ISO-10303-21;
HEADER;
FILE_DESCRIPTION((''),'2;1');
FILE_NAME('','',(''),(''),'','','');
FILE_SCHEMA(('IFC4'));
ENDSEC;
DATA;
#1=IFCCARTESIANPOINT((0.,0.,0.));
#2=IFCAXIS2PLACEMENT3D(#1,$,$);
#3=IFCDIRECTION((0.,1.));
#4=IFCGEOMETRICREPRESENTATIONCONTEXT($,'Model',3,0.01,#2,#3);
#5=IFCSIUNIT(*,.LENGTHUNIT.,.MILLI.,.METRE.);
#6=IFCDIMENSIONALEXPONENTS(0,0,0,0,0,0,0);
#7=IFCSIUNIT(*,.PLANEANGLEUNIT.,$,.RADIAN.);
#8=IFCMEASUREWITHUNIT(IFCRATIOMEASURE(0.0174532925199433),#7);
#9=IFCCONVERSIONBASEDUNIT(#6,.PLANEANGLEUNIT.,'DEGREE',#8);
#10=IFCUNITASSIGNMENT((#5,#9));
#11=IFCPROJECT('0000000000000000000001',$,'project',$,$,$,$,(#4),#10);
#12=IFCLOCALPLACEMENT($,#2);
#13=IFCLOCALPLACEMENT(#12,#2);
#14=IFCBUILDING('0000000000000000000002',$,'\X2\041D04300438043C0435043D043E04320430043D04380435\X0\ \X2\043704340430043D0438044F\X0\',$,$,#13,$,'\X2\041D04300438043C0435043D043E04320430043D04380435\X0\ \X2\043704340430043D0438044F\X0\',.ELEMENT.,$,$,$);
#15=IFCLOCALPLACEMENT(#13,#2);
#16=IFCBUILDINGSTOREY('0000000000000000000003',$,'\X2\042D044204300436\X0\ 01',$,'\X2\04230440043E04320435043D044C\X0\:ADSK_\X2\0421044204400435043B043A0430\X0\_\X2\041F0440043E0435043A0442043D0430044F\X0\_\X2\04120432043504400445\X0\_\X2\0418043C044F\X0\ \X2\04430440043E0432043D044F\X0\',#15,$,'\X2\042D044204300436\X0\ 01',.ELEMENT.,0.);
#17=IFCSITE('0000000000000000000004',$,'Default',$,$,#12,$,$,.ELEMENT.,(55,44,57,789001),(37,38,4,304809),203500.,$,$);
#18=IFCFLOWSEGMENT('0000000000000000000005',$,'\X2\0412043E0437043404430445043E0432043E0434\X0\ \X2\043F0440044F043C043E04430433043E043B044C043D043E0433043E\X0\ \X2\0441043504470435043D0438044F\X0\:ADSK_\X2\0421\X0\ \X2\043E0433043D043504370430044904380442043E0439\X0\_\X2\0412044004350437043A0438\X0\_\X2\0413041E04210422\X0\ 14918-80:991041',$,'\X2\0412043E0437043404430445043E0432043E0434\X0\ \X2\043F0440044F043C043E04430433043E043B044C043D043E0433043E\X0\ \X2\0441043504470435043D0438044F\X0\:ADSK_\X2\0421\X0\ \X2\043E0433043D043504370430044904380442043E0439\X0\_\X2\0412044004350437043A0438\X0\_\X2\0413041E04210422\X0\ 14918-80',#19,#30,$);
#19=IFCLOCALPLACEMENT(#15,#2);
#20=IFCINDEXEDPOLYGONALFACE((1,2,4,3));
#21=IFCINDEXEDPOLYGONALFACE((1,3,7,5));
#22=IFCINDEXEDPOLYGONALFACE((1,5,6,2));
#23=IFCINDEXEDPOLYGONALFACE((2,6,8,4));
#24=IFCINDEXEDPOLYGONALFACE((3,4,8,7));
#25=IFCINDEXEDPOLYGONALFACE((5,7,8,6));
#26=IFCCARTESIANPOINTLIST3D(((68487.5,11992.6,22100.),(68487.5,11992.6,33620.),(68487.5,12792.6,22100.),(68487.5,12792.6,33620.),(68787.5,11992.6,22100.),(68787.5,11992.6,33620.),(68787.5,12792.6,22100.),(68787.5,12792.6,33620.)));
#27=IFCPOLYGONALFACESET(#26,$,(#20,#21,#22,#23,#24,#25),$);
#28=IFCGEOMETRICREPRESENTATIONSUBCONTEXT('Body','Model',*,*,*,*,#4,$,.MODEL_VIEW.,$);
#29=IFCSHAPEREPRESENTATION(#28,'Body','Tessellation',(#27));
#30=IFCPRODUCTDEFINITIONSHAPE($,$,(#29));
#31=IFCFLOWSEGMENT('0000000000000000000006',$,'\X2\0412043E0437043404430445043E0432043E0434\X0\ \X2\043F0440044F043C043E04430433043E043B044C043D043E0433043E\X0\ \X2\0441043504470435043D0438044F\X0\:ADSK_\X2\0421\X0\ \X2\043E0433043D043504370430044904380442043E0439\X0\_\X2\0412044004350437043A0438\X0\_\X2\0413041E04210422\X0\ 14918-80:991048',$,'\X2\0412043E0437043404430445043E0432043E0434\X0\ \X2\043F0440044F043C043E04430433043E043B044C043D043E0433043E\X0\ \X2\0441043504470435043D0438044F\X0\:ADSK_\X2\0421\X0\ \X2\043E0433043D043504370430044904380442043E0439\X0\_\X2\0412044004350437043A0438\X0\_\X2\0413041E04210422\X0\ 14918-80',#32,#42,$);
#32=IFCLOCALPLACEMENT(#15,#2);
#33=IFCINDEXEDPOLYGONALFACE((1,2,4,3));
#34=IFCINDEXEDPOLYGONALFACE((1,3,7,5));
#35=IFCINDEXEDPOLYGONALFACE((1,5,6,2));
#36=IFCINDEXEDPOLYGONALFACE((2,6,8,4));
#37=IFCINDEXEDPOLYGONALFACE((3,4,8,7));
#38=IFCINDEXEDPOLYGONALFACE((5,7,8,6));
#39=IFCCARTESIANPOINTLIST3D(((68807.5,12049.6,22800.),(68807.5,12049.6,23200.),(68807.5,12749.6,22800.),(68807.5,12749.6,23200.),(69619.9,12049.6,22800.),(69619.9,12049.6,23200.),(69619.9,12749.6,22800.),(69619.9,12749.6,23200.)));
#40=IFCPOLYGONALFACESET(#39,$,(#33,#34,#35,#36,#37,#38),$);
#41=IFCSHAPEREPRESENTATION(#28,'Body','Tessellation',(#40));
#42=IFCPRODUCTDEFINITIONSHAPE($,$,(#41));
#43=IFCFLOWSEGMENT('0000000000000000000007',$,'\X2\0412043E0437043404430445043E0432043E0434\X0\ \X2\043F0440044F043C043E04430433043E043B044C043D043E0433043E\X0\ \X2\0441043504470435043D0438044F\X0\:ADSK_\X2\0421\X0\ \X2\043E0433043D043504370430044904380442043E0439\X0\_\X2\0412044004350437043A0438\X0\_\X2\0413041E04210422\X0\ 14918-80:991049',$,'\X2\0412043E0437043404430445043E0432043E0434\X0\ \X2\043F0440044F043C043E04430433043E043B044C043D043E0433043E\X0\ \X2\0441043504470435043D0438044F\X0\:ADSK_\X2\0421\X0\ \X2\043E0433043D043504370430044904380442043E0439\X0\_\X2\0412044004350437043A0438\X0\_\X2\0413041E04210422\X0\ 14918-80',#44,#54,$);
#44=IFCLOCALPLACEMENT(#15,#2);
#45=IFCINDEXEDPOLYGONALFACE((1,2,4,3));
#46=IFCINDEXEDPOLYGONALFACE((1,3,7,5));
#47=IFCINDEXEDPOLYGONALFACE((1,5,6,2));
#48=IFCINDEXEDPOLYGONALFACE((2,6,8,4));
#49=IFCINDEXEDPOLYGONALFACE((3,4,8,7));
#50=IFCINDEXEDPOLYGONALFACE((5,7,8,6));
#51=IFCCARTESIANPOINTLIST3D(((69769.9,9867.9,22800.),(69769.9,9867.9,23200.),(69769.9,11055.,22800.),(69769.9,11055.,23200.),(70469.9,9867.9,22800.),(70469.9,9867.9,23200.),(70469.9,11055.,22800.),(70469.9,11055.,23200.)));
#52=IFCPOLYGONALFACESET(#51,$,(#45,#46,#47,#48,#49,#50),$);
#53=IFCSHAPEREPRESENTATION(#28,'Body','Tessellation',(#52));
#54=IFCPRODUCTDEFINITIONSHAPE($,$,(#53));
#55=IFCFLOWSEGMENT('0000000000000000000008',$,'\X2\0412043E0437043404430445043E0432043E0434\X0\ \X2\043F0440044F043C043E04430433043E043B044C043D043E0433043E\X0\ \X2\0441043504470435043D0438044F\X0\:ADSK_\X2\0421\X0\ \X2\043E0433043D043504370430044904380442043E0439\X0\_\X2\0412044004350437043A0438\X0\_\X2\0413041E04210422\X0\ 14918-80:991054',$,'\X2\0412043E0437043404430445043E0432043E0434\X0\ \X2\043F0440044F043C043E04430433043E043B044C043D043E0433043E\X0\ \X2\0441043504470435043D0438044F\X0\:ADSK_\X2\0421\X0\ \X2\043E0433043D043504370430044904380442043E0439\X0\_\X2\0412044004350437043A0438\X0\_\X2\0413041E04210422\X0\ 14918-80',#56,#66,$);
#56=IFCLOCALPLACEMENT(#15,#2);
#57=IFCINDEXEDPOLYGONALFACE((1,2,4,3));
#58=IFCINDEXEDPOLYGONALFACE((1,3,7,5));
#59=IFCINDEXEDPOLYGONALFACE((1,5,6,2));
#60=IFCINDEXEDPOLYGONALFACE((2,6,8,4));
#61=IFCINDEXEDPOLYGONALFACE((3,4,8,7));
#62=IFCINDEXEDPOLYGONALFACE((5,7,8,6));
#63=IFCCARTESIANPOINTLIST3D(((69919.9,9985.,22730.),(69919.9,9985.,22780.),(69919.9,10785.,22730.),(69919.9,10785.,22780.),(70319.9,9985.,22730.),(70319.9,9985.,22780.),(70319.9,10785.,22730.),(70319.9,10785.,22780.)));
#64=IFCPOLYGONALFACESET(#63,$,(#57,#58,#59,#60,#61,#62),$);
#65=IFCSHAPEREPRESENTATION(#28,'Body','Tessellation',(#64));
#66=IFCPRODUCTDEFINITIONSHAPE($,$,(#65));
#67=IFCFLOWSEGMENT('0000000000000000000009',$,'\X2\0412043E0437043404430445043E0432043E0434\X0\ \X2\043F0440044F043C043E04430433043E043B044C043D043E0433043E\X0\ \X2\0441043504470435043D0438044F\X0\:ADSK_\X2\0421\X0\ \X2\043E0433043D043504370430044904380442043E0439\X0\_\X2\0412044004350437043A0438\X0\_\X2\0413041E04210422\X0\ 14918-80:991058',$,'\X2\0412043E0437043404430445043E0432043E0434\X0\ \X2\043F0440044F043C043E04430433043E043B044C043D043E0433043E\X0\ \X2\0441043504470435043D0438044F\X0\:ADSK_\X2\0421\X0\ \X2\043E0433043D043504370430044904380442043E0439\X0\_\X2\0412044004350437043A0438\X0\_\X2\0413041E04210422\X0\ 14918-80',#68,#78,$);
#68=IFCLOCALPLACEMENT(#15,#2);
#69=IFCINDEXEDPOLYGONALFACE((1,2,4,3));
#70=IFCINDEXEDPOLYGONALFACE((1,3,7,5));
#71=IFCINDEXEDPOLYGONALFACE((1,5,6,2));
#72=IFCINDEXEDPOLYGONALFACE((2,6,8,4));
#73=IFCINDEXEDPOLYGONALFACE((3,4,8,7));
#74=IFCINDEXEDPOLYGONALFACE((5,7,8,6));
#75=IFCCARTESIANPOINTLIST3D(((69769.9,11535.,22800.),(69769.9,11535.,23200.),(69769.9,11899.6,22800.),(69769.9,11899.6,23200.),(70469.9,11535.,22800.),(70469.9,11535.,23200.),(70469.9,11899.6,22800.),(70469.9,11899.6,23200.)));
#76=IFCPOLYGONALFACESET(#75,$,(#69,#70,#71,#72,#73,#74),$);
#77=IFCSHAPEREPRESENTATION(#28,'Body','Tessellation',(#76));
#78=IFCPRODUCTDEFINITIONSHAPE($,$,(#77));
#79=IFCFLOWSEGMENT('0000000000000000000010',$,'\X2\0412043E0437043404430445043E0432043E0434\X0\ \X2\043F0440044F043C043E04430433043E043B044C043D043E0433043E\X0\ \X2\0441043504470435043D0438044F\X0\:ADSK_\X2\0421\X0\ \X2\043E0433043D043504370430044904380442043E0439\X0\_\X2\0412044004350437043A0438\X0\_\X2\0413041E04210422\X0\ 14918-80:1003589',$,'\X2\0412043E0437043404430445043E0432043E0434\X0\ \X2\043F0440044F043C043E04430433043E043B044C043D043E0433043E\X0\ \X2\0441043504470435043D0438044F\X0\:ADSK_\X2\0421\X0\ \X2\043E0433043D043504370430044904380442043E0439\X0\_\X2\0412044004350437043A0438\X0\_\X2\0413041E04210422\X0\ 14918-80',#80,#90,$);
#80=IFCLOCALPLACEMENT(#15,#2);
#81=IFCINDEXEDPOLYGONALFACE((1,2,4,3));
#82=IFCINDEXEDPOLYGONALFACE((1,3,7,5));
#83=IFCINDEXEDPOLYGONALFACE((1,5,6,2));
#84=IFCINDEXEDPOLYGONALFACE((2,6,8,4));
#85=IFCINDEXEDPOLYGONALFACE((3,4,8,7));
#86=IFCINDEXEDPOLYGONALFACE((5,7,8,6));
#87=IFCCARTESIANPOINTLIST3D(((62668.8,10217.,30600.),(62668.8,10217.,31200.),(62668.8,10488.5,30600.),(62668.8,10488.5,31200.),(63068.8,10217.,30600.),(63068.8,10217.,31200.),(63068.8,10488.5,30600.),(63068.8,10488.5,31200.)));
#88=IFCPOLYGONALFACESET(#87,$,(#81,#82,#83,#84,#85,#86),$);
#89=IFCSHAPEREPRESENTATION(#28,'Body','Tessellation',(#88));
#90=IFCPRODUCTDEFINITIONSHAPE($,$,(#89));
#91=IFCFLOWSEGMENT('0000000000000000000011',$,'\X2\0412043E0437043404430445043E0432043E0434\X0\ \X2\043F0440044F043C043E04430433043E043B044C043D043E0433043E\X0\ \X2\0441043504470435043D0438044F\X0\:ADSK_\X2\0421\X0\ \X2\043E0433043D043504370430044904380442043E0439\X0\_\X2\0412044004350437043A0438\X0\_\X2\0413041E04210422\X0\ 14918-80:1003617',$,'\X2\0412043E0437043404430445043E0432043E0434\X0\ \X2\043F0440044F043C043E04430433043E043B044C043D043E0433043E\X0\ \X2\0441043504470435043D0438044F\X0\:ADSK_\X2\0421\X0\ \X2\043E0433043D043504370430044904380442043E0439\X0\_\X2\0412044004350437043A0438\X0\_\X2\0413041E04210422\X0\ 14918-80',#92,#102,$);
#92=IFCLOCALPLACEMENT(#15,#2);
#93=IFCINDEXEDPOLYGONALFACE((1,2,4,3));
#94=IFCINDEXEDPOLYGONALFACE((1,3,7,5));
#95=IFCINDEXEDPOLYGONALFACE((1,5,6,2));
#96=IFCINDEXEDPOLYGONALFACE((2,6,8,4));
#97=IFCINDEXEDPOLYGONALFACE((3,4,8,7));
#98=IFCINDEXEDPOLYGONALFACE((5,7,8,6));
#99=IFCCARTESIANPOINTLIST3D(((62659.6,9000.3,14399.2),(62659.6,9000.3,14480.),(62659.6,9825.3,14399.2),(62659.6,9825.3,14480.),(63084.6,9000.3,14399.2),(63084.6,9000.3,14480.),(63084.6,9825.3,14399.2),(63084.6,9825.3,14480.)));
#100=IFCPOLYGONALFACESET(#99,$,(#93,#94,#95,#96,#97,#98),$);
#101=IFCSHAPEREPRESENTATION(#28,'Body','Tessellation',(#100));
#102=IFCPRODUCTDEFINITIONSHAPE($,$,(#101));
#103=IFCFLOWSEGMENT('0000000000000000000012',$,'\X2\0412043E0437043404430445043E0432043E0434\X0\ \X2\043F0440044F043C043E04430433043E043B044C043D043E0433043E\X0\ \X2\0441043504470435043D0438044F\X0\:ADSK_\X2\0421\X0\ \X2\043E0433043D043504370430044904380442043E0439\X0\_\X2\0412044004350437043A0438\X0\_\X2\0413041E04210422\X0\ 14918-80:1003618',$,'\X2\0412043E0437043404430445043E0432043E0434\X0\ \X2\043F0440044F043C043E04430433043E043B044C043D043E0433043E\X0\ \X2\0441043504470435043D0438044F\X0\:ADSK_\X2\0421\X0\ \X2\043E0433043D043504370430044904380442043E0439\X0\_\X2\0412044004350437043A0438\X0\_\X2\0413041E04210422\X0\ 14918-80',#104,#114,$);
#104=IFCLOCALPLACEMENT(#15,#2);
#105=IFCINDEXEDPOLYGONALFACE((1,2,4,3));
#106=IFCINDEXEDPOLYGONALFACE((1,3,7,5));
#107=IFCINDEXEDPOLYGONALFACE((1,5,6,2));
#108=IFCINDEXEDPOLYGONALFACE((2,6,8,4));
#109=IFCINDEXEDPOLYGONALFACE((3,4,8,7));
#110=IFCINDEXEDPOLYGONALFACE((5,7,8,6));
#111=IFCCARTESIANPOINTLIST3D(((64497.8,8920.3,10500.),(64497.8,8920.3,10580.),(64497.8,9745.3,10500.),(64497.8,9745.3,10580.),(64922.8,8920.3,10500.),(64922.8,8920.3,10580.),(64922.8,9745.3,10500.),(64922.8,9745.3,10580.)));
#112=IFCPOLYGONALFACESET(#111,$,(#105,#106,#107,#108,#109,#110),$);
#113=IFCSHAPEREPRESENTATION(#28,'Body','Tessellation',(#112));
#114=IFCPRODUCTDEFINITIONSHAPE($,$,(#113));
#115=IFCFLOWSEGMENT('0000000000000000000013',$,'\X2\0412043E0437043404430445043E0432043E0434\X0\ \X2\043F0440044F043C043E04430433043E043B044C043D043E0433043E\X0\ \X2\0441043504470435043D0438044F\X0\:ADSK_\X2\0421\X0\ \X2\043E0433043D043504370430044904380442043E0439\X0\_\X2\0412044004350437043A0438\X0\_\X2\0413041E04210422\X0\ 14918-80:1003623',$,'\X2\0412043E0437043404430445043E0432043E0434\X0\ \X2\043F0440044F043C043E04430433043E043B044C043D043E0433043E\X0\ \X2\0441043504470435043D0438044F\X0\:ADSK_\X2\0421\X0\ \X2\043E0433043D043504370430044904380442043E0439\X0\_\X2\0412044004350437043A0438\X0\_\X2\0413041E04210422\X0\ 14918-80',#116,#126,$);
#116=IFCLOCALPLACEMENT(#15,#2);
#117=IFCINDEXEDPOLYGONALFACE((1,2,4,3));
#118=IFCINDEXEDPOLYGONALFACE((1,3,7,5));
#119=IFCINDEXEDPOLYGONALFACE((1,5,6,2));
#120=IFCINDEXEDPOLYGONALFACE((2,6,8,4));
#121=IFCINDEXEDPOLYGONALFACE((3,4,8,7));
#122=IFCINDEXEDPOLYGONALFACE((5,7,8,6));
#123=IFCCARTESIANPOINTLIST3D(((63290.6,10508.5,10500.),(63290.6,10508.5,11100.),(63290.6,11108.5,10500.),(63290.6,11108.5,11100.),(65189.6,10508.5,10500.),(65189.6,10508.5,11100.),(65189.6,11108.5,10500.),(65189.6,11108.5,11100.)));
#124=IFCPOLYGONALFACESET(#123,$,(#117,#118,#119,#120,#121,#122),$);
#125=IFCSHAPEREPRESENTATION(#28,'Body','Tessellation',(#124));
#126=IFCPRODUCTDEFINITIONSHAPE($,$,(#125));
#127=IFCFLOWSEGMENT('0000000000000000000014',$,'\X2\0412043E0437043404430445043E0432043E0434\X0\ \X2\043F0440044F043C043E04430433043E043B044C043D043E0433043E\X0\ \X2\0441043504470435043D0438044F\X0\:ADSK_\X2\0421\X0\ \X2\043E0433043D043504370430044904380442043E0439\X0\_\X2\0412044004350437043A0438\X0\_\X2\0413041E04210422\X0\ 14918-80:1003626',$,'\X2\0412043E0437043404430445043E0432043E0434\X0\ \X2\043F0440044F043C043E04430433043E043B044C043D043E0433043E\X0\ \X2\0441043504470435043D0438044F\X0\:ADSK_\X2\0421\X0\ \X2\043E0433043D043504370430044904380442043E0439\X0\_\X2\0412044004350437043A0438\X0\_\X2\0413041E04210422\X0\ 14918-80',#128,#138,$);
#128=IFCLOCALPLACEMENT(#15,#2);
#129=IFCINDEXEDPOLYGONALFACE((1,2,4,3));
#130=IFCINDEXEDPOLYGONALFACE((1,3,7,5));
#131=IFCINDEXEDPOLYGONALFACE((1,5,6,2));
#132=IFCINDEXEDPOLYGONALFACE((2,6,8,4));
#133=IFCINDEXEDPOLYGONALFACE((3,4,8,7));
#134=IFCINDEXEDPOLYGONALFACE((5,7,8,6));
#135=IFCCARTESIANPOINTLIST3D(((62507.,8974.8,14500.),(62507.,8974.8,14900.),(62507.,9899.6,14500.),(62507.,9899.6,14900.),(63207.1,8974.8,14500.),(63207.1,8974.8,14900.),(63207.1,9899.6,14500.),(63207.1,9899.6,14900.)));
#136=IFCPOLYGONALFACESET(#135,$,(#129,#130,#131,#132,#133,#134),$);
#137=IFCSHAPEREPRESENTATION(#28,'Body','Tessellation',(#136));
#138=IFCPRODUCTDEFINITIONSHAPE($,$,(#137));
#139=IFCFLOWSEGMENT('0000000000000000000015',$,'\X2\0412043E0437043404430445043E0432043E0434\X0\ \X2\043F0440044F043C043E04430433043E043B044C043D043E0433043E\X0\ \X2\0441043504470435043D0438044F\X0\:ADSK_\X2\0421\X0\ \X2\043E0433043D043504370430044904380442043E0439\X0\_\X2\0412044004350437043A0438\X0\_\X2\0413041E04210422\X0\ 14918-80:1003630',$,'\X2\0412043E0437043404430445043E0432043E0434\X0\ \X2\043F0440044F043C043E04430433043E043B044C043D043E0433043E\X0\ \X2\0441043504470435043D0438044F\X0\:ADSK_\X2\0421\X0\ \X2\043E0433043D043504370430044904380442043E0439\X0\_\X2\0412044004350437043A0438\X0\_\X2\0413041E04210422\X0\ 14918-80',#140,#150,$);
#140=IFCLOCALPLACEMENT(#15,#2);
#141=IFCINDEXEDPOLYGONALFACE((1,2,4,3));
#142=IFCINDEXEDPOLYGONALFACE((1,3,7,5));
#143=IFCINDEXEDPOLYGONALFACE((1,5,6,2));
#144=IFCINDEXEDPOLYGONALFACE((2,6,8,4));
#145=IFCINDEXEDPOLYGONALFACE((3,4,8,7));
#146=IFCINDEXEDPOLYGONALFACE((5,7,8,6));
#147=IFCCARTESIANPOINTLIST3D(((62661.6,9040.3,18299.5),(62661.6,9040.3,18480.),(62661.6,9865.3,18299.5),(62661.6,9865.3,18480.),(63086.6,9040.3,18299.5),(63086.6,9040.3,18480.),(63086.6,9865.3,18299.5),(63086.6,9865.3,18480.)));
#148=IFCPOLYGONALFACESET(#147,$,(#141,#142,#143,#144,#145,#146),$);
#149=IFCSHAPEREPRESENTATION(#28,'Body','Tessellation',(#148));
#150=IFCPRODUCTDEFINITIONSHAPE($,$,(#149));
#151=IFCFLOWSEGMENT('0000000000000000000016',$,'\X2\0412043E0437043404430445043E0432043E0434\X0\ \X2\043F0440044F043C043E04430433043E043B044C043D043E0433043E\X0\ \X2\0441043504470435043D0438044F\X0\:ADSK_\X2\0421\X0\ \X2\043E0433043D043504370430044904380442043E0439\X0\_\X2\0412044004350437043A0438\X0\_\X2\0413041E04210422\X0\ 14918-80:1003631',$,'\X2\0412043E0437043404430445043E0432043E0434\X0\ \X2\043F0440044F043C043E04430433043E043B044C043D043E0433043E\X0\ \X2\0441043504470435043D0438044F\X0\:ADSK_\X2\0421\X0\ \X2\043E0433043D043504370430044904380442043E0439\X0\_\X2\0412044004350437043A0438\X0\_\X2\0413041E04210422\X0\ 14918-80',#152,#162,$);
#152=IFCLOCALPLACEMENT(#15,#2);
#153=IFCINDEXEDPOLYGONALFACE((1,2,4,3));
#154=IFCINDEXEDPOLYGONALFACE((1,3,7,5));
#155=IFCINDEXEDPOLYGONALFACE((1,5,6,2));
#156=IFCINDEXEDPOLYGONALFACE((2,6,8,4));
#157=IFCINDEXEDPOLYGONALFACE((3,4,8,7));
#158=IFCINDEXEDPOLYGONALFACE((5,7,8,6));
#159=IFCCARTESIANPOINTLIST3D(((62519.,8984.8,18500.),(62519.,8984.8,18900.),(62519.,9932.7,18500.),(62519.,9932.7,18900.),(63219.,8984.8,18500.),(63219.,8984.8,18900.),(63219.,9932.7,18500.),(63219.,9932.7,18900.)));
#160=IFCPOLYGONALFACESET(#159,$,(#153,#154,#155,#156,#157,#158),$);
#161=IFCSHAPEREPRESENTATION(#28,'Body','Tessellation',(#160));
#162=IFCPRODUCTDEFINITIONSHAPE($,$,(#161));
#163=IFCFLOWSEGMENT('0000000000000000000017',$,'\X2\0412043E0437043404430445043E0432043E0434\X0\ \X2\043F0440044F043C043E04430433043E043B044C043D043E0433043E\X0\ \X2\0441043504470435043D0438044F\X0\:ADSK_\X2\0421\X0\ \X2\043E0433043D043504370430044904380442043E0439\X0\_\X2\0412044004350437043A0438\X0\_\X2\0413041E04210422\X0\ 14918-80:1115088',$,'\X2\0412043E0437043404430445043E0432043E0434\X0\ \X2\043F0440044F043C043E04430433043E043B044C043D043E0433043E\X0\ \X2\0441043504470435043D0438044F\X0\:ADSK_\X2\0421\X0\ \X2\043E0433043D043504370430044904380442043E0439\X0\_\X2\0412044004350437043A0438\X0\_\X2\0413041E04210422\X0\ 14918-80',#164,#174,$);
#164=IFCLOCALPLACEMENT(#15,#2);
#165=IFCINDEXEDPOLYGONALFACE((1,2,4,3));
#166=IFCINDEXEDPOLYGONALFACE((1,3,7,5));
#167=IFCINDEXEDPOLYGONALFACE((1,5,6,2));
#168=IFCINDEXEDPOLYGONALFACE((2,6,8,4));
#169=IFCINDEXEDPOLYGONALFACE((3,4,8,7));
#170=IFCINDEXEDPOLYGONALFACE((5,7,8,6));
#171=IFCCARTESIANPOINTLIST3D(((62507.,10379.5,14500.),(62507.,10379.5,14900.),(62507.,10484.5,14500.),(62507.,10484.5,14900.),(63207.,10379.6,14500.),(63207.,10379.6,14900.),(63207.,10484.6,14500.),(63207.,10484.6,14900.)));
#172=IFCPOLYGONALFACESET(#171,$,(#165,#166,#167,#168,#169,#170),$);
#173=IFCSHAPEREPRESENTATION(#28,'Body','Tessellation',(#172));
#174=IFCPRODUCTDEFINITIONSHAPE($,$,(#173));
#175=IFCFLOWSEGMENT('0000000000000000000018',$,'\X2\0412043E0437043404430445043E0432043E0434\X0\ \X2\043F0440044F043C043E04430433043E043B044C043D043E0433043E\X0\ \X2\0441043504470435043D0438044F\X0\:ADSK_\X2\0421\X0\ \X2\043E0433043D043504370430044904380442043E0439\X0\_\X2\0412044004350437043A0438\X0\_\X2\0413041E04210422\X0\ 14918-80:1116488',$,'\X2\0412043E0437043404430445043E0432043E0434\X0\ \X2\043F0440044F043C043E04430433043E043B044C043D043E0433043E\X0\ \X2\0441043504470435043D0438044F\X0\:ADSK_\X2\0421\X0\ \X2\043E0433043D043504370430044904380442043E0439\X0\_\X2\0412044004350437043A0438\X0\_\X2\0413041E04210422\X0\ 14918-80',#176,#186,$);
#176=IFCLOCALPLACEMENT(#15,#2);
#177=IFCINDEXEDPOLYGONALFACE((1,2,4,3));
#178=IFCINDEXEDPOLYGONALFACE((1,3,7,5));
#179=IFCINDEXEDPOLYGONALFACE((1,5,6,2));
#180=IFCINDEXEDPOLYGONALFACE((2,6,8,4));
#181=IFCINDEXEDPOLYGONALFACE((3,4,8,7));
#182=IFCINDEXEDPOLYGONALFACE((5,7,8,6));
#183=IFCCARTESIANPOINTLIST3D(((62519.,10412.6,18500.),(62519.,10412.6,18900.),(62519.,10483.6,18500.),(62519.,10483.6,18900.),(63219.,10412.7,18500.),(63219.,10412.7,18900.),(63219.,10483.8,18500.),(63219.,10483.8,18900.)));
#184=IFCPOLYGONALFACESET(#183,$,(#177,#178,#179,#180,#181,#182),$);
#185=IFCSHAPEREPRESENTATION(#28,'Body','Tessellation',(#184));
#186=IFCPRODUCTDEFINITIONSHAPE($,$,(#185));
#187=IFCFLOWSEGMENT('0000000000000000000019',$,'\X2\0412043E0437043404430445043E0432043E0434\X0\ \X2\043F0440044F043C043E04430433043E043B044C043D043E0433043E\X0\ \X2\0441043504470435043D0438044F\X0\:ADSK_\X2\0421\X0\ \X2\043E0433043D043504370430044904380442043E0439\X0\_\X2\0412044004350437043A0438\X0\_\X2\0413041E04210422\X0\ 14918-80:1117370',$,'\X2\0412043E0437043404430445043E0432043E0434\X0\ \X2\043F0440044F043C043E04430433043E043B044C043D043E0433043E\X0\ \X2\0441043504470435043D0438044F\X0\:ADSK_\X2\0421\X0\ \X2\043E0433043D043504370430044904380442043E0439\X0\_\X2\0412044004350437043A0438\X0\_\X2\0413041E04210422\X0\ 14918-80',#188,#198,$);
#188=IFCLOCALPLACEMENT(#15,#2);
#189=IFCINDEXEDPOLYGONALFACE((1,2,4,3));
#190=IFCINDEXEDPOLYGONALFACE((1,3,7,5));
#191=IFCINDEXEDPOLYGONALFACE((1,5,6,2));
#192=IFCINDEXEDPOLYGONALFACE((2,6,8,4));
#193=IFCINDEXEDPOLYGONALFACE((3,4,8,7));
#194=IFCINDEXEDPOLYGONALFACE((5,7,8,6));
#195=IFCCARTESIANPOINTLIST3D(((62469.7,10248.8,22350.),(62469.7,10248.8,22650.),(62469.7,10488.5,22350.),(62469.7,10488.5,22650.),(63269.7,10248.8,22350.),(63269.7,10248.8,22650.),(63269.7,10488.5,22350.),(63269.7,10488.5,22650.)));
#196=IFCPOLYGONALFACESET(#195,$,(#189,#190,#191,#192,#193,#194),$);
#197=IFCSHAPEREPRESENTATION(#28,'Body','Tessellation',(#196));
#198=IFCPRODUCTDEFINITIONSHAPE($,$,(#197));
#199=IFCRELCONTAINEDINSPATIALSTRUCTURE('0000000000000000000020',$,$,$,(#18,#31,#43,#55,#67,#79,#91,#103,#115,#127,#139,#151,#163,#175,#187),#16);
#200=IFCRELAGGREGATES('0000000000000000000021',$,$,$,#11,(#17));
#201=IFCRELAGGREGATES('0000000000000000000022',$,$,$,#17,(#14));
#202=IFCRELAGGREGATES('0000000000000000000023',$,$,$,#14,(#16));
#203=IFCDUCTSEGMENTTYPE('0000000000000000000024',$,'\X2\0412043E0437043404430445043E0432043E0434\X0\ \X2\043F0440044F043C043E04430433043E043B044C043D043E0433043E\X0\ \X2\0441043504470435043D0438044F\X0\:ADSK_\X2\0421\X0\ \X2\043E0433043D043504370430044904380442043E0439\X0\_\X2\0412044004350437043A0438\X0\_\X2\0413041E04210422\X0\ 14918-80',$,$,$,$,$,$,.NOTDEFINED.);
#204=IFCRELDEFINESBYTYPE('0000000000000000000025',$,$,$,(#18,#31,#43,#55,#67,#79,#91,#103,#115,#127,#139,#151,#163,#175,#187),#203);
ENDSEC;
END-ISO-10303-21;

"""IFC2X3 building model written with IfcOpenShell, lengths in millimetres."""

from ifc_helpers import new_model, entity, si_unit, converted_unit, direction, frame, origin, origin_2d_with_axis, place, context, subcontext, project, spatial, rectangle, extrude, type_object, element, save


model = new_model("IFC2X3")

# Units and contexts
model_context = context("Model", 3, precision=0.01, world=origin(), true_north=direction((0.0, 1.0)))
body_context = subcontext(model_context, "Body", "Model", "MODEL_VIEW")
ifc_project = project(units=[si_unit("LENGTHUNIT", "METRE", prefix="MILLI"), converted_unit("PLANEANGLEUNIT", "DEGREE", entity("IfcRatioMeasure", 0.0174532925199433), si_unit("PLANEANGLEUNIT", "RADIAN"), dimensions=[0, 0, 0, 0, 0, 0, 0])], contexts=[model_context])

# Site, building, storey
site_placement = place(None, origin())
site = spatial("IfcSite", under=ifc_project, at=site_placement, Name="Default", CompositionType="ELEMENT", RefLatitude=(55, 44, 57, 789001), RefLongitude=(37, 38, 4, 304809), RefElevation=203500.0)
building_placement = place(site_placement, origin())
building = spatial("IfcBuilding", under=site, at=building_placement, Name="Наименование здания", LongName="Наименование здания", CompositionType="ELEMENT")
storey_placement = place(building_placement, origin())
storey = spatial("IfcBuildingStorey", under=building, at=storey_placement, Name="Этаж 01", ObjectType="Уровень:ADSK_Стрелка_Проектная_Вверх_Имя уровня", LongName="Этаж 01", CompositionType="ELEMENT", Elevation=0.0)

# Flow segments
duct_segment_type = type_object("IfcDuctSegmentType", Name="Воздуховод прямоугольного сечения:ADSK_С огнезащитой_Врезки_ГОСТ 14918-80", PredefinedType="NOTDEFINED")
flow_segment_1_placement = place(storey_placement, frame((68487.5, 11992.6, 22100.0)))
element("IfcFlowSegment", 1, at=flow_segment_1_placement, inside=storey, type_object=duct_segment_type, Name="Воздуховод прямоугольного сечения:ADSK_С огнезащитой_Врезки_ГОСТ 14918-80:991041", ObjectType="Воздуховод прямоугольного сечения:ADSK_С огнезащитой_Врезки_ГОСТ 14918-80", context=body_context, shape_type="SweptSolid", body=[
    extrude(rectangle(XDim=300.0, YDim=800.0, at=origin_2d_with_axis()), frame((150.0, 400.0, 0.0), z_axis=(0.0, 0.0, 1.0), x_axis=(-1.0, 0.0, 0.0)), (0.0, 0.0, 1.0), 11520.0),
])
flow_segment_2_placement = place(storey_placement, frame((68807.5, 12049.6, 22800.0)))
element("IfcFlowSegment", 2, at=flow_segment_2_placement, inside=storey, type_object=duct_segment_type, Name="Воздуховод прямоугольного сечения:ADSK_С огнезащитой_Врезки_ГОСТ 14918-80:991048", ObjectType="Воздуховод прямоугольного сечения:ADSK_С огнезащитой_Врезки_ГОСТ 14918-80", context=body_context, shape_type="SweptSolid", body=[
    extrude(rectangle(XDim=812.4, YDim=700.0, at=origin_2d_with_axis()), frame((406.2, 350.0, 0.0), z_axis=(0.0, 0.0, 1.0), x_axis=(-1.0, 0.0, 0.0)), (0.0, 0.0, 1.0), 400.0),
])
flow_segment_3_placement = place(storey_placement, frame((69769.9, 9867.9, 22800.0)))
element("IfcFlowSegment", 3, at=flow_segment_3_placement, inside=storey, type_object=duct_segment_type, Name="Воздуховод прямоугольного сечения:ADSK_С огнезащитой_Врезки_ГОСТ 14918-80:991049", ObjectType="Воздуховод прямоугольного сечения:ADSK_С огнезащитой_Врезки_ГОСТ 14918-80", context=body_context, shape_type="SweptSolid", body=[
    extrude(rectangle(XDim=1187.1, YDim=700.0, at=origin_2d_with_axis()), frame((350.0, 593.5, 0.0), z_axis=(0.0, 0.0, 1.0), x_axis=(0.0, -1.0, 0.0)), (0.0, 0.0, 1.0), 400.0),
])
flow_segment_4_placement = place(storey_placement, frame((69919.9, 9985.0, 22730.0)))
element("IfcFlowSegment", 4, at=flow_segment_4_placement, inside=storey, type_object=duct_segment_type, Name="Воздуховод прямоугольного сечения:ADSK_С огнезащитой_Врезки_ГОСТ 14918-80:991054", ObjectType="Воздуховод прямоугольного сечения:ADSK_С огнезащитой_Врезки_ГОСТ 14918-80", context=body_context, shape_type="SweptSolid", body=[
    extrude(rectangle(XDim=800.0, YDim=400.0, at=origin_2d_with_axis()), frame((200.0, 400.0, 0.0), z_axis=(0.0, 0.0, 1.0), x_axis=(0.0, 1.0, 0.0)), (0.0, 0.0, 1.0), 50.0),
])
flow_segment_5_placement = place(storey_placement, frame((69769.9, 11535.0, 22800.0)))
element("IfcFlowSegment", 5, at=flow_segment_5_placement, inside=storey, type_object=duct_segment_type, Name="Воздуховод прямоугольного сечения:ADSK_С огнезащитой_Врезки_ГОСТ 14918-80:991058", ObjectType="Воздуховод прямоугольного сечения:ADSK_С огнезащитой_Врезки_ГОСТ 14918-80", context=body_context, shape_type="SweptSolid", body=[
    extrude(rectangle(XDim=364.6, YDim=700.0, at=origin_2d_with_axis()), frame((350.0, 182.3, 0.0), z_axis=(0.0, 0.0, 1.0), x_axis=(0.0, -1.0, 0.0)), (0.0, 0.0, 1.0), 400.0),
])
flow_segment_6_placement = place(storey_placement, frame((62668.8, 10217.0, 30600.0)))
element("IfcFlowSegment", 6, at=flow_segment_6_placement, inside=storey, type_object=duct_segment_type, Name="Воздуховод прямоугольного сечения:ADSK_С огнезащитой_Врезки_ГОСТ 14918-80:1003589", ObjectType="Воздуховод прямоугольного сечения:ADSK_С огнезащитой_Врезки_ГОСТ 14918-80", context=body_context, shape_type="SweptSolid", body=[
    extrude(rectangle(XDim=271.5, YDim=400.0, at=origin_2d_with_axis()), frame((200.0, 135.7, 0.0), z_axis=(0.0, 0.0, 1.0), x_axis=(0.0, 1.0, 0.0)), (0.0, 0.0, 1.0), 600.0),
])
flow_segment_7_placement = place(storey_placement, frame((62659.6, 9000.3, 14399.2)))
element("IfcFlowSegment", 7, at=flow_segment_7_placement, inside=storey, type_object=duct_segment_type, Name="Воздуховод прямоугольного сечения:ADSK_С огнезащитой_Врезки_ГОСТ 14918-80:1003617", ObjectType="Воздуховод прямоугольного сечения:ADSK_С огнезащитой_Врезки_ГОСТ 14918-80", context=body_context, shape_type="SweptSolid", body=[
    extrude(rectangle(XDim=425.0, YDim=825.0, at=origin_2d_with_axis()), frame((212.5, 412.5, 0.0)), (0.0, 0.0, 1.0), 80.7),
])
flow_segment_8_placement = place(storey_placement, frame((64497.8, 8920.3, 10500.0)))
element("IfcFlowSegment", 8, at=flow_segment_8_placement, inside=storey, type_object=duct_segment_type, Name="Воздуховод прямоугольного сечения:ADSK_С огнезащитой_Врезки_ГОСТ 14918-80:1003618", ObjectType="Воздуховод прямоугольного сечения:ADSK_С огнезащитой_Врезки_ГОСТ 14918-80", context=body_context, shape_type="SweptSolid", body=[
    extrude(rectangle(XDim=825.0, YDim=425.0, at=origin_2d_with_axis()), frame((212.5, 412.5, 0.0), z_axis=(0.0, 0.0, 1.0), x_axis=(0.0, 1.0, 0.0)), (0.0, 0.0, 1.0), 80.0),
])
flow_segment_9_placement = place(storey_placement, frame((63290.6, 10508.5, 10500.0)))
element("IfcFlowSegment", 9, at=flow_segment_9_placement, inside=storey, type_object=duct_segment_type, Name="Воздуховод прямоугольного сечения:ADSK_С огнезащитой_Врезки_ГОСТ 14918-80:1003623", ObjectType="Воздуховод прямоугольного сечения:ADSK_С огнезащитой_Врезки_ГОСТ 14918-80", context=body_context, shape_type="SweptSolid", body=[
    extrude(rectangle(XDim=1899.1, YDim=600.0, at=origin_2d_with_axis()), frame((949.5, 300.0, 0.0)), (0.0, 0.0, 1.0), 600.0),
])
flow_segment_10_placement = place(storey_placement, frame((62507.1, 8974.8, 14500.0)))
element("IfcFlowSegment", 10, at=flow_segment_10_placement, inside=storey, type_object=duct_segment_type, Name="Воздуховод прямоугольного сечения:ADSK_С огнезащитой_Врезки_ГОСТ 14918-80:1003626", ObjectType="Воздуховод прямоугольного сечения:ADSK_С огнезащитой_Врезки_ГОСТ 14918-80", context=body_context, shape_type="SweptSolid", body=[
    extrude(rectangle(XDim=924.8, YDim=700.0, at=origin_2d_with_axis()), frame((350.0, 462.4, 0.0), z_axis=(0.0, 0.0, 1.0), x_axis=(0.0, -1.0, 0.0)), (0.0, 0.0, 1.0), 400.0),
])
flow_segment_11_placement = place(storey_placement, frame((62661.6, 9040.3, 18299.5)))
element("IfcFlowSegment", 11, at=flow_segment_11_placement, inside=storey, type_object=duct_segment_type, Name="Воздуховод прямоугольного сечения:ADSK_С огнезащитой_Врезки_ГОСТ 14918-80:1003630", ObjectType="Воздуховод прямоугольного сечения:ADSK_С огнезащитой_Врезки_ГОСТ 14918-80", context=body_context, shape_type="SweptSolid", body=[
    extrude(rectangle(XDim=425.0, YDim=825.0, at=origin_2d_with_axis()), frame((212.5, 412.5, 0.0), z_axis=(0.0, 0.0, 1.0), x_axis=(-1.0, 0.0, 0.0)), (0.0, 0.0, 1.0), 180.5),
])
flow_segment_12_placement = place(storey_placement, frame((62519.0, 8984.8, 18500.0)))
element("IfcFlowSegment", 12, at=flow_segment_12_placement, inside=storey, type_object=duct_segment_type, Name="Воздуховод прямоугольного сечения:ADSK_С огнезащитой_Врезки_ГОСТ 14918-80:1003631", ObjectType="Воздуховод прямоугольного сечения:ADSK_С огнезащитой_Врезки_ГОСТ 14918-80", context=body_context, shape_type="SweptSolid", body=[
    extrude(rectangle(XDim=947.8, YDim=700.0, at=origin_2d_with_axis()), frame((350.0, 473.9, 0.0), z_axis=(0.0, 0.0, 1.0), x_axis=(0.0, 1.0, 0.0)), (0.0, 0.0, 1.0), 400.0),
])
flow_segment_13_placement = place(storey_placement, frame((62507.0, 10379.5, 14500.0)))
element("IfcFlowSegment", 13, at=flow_segment_13_placement, inside=storey, type_object=duct_segment_type, Name="Воздуховод прямоугольного сечения:ADSK_С огнезащитой_Врезки_ГОСТ 14918-80:1115088", ObjectType="Воздуховод прямоугольного сечения:ADSK_С огнезащитой_Врезки_ГОСТ 14918-80", context=body_context, shape_type="SweptSolid", body=[
    extrude(rectangle(XDim=104.9, YDim=700.0, at=origin_2d_with_axis()), frame((350.0, 52.5, 0.0), z_axis=(0.0, 0.0, 1.0), x_axis=(-0.00013, 1.0, 0.0)), (0.0, 0.0, 1.0), 400.0),
])
flow_segment_14_placement = place(storey_placement, frame((62519.0, 10412.6, 18500.0)))
element("IfcFlowSegment", 14, at=flow_segment_14_placement, inside=storey, type_object=duct_segment_type, Name="Воздуховод прямоугольного сечения:ADSK_С огнезащитой_Врезки_ГОСТ 14918-80:1116488", ObjectType="Воздуховод прямоугольного сечения:ADSK_С огнезащитой_Врезки_ГОСТ 14918-80", context=body_context, shape_type="SweptSolid", body=[
    extrude(rectangle(XDim=71.0, YDim=700.0, at=origin_2d_with_axis()), frame((350.0, 35.6, 0.0), z_axis=(0.0, 0.0, 1.0), x_axis=(-0.000157, 1.0, 0.0)), (0.0, 0.0, 1.0), 400.0),
])
flow_segment_15_placement = place(storey_placement, frame((62469.7, 10248.8, 22350.0)))
element("IfcFlowSegment", 15, at=flow_segment_15_placement, inside=storey, type_object=duct_segment_type, Name="Воздуховод прямоугольного сечения:ADSK_С огнезащитой_Врезки_ГОСТ 14918-80:1117370", ObjectType="Воздуховод прямоугольного сечения:ADSK_С огнезащитой_Врезки_ГОСТ 14918-80", context=body_context, shape_type="SweptSolid", body=[
    extrude(rectangle(XDim=239.7, YDim=800.0, at=origin_2d_with_axis()), frame((400.0, 119.8, 0.0), z_axis=(0.0, 0.0, 1.0), x_axis=(-0.000003, -1.0, 0.0)), (0.0, 0.0, 1.0), 300.0),
])

save(model, "model.ifc")
